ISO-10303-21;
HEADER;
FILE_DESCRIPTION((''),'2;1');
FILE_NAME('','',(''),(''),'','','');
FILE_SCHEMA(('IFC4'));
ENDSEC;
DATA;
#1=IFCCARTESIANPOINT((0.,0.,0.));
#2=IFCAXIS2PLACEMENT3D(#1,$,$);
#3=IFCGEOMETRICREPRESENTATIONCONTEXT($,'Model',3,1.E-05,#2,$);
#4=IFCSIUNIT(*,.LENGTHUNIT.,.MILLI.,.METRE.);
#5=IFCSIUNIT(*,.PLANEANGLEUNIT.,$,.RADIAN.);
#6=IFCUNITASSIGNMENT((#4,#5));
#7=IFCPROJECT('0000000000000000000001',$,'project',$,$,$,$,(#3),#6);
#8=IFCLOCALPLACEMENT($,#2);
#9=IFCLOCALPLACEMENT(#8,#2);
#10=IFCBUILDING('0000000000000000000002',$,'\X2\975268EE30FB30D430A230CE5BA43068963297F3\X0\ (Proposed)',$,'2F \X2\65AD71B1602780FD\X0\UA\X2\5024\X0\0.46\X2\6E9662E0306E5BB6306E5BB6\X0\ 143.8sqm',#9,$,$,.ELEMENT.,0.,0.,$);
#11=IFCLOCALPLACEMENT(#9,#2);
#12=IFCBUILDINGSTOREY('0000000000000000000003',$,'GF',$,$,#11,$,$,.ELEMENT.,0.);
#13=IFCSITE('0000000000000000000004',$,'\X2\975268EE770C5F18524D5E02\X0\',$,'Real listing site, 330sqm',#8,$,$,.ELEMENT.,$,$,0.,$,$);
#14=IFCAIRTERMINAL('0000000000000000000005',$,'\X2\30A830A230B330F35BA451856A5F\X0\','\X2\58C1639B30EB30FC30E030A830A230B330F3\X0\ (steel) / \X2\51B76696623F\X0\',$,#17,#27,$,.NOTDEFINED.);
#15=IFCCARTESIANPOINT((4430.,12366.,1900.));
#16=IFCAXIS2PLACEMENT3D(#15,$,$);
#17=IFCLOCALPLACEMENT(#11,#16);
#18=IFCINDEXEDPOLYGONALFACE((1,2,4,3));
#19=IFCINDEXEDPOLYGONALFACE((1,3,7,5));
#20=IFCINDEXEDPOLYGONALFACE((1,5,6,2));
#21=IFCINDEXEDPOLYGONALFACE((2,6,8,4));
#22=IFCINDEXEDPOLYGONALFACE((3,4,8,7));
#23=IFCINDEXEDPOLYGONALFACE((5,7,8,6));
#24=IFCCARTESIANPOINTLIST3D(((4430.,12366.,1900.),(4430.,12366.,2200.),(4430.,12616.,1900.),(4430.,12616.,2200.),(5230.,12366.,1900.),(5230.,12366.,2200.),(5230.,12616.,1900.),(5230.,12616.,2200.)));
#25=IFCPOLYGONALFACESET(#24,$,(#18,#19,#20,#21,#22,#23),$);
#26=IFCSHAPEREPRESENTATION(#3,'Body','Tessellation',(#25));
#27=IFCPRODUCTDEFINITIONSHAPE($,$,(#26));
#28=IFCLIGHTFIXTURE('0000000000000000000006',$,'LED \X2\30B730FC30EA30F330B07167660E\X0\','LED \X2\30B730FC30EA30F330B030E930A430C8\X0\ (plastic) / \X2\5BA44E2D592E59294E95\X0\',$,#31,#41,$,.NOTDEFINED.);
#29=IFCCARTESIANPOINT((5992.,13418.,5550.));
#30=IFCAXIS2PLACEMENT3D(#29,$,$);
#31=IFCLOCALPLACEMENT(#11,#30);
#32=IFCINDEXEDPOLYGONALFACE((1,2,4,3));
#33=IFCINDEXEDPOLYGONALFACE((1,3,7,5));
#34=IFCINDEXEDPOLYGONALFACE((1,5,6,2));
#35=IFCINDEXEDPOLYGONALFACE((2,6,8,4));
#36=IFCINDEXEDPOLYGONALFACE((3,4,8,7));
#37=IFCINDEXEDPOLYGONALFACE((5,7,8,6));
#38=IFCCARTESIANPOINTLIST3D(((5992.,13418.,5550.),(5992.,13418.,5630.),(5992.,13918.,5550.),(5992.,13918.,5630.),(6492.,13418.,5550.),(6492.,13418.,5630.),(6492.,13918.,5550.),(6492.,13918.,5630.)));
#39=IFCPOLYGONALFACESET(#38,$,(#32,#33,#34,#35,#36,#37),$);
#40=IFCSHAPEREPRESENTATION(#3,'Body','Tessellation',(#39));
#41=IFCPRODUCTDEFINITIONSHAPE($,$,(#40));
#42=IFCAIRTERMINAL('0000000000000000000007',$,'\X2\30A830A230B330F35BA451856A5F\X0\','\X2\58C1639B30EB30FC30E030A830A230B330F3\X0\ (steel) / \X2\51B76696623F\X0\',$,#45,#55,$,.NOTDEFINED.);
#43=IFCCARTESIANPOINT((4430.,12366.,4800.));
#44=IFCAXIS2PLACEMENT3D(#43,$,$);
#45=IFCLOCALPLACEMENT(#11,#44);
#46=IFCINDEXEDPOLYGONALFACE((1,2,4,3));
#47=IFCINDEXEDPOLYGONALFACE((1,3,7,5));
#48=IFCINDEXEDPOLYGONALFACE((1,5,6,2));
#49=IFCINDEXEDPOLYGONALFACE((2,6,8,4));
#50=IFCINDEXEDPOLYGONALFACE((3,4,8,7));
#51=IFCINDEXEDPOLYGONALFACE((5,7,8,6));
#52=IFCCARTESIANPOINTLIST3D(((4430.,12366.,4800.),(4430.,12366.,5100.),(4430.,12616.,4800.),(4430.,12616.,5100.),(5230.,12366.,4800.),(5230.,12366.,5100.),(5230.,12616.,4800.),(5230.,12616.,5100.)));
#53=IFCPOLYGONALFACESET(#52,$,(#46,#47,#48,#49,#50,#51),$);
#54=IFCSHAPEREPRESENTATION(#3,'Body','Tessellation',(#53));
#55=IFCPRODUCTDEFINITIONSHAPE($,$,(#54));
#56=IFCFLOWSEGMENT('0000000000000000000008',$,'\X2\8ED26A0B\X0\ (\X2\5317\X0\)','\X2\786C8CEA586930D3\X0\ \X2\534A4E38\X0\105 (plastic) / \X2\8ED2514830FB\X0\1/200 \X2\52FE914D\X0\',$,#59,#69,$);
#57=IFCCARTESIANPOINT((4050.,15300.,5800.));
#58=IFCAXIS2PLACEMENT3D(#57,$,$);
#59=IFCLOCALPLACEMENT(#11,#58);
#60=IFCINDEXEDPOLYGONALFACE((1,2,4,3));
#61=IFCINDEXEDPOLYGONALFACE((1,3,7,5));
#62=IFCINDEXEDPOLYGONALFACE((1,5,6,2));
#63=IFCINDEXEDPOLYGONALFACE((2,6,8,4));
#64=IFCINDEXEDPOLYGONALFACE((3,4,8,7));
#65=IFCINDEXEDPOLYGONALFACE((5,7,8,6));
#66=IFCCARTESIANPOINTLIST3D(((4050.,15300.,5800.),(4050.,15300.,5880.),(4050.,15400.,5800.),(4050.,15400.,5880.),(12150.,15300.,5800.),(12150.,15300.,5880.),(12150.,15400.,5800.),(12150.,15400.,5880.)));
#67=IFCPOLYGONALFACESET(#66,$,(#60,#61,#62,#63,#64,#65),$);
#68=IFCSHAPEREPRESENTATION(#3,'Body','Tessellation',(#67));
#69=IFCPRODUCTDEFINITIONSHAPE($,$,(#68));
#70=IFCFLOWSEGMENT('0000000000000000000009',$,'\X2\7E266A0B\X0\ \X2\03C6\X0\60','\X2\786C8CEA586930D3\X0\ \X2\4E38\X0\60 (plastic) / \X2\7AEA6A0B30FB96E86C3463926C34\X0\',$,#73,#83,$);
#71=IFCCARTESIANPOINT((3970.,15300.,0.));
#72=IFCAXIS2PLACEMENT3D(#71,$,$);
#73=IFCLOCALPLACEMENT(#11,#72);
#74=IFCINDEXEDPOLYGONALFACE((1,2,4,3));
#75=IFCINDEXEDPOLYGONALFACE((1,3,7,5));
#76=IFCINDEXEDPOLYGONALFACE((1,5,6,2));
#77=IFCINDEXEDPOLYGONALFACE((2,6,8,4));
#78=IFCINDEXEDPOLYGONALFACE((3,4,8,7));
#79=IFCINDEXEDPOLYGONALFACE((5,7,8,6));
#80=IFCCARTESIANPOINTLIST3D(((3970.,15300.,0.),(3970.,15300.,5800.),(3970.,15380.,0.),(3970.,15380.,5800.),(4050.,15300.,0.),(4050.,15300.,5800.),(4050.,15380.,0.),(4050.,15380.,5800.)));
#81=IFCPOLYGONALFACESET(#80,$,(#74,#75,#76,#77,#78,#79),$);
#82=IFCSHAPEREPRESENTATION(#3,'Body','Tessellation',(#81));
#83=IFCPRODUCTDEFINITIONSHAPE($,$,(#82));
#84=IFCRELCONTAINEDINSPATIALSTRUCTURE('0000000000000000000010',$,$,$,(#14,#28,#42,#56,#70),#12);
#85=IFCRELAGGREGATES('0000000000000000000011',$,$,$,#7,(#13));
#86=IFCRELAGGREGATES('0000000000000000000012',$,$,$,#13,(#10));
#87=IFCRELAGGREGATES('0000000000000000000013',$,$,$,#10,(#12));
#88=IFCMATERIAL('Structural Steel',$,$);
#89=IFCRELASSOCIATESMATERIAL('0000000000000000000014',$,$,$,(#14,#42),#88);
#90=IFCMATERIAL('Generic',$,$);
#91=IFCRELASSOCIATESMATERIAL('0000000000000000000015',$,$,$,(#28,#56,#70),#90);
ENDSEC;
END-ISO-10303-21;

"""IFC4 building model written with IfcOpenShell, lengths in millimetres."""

from ifc_helpers import new_model, si_unit, frame, frame_2d, origin, place, context, project, spatial, rectangle, extrude, material, element, save


model = new_model("IFC4")

# Units and contexts
model_context = context("Model", 3, precision=1e-05, world=origin())
ifc_project = project(units=[si_unit("LENGTHUNIT", "METRE", prefix="MILLI"), si_unit("PLANEANGLEUNIT", "RADIAN")], contexts=[model_context])

# Site, building, storey
site_placement = place(None, origin())
site = spatial("IfcSite", under=ifc_project, at=site_placement, Name="青森県弘前市", ObjectType="Real listing site, 330sqm", CompositionType="ELEMENT", RefElevation=0.0)
building_placement = place(site_placement, origin())
building = spatial("IfcBuilding", under=site, at=building_placement, Name="青森・ピアノ室と防音 (Proposed)", ObjectType="2F 断熱性能UA値0.46準拠の家の家 143.8sqm", CompositionType="ELEMENT", ElevationOfRefHeight=0.0, ElevationOfTerrain=0.0)
storey_placement = place(building_placement, origin())
storey = spatial("IfcBuildingStorey", under=building, at=storey_placement, Name="GF", CompositionType="ELEMENT", Elevation=0.0)

# Shared definitions
ifc_material_1 = material(Name="Generic")

# Shared definitions
ifc_material_2 = material(Name="Structural Steel")

# Air terminal
air_terminal_1_placement = place(storey_placement, frame((4430.0, 12366.0, 1900.0)))
element("IfcAirTerminal", 1, at=air_terminal_1_placement, inside=storey, material=ifc_material_2, Name="エアコン室内機", Description="壁掛ルームエアコン (steel) / 冷暖房", PredefinedType="NOTDEFINED", context=model_context, shape_type="SweptSolid", body=[
    extrude(rectangle(XDim=800.0, YDim=250.0, at=frame_2d((400.0, 125.0))), frame((4430.0, 12366.0, 1900.0)), (0.0, 0.0, 1.0), 300.0),
])

# Light fixture
light_fixture_placement = place(storey_placement, frame((5992.0, 13418.0, 5550.0)))
element("IfcLightFixture", 2, at=light_fixture_placement, inside=storey, material=ifc_material_1, Name="LED シーリング照明", Description="LED シーリングライト (plastic) / 室中央天井", PredefinedType="NOTDEFINED", context=model_context, shape_type="SweptSolid", body=[
    extrude(rectangle(XDim=500.0, YDim=500.0, at=frame_2d((250.0, 250.0))), frame((5992.0, 13418.0, 5550.0)), (0.0, 0.0, 1.0), 80.0),
])

# Air terminal
air_terminal_2_placement = place(storey_placement, frame((4430.0, 12366.0, 4800.0)))
element("IfcAirTerminal", 3, at=air_terminal_2_placement, inside=storey, material=ifc_material_2, Name="エアコン室内機", Description="壁掛ルームエアコン (steel) / 冷暖房", PredefinedType="NOTDEFINED", context=model_context, shape_type="SweptSolid", body=[
    extrude(rectangle(XDim=800.0, YDim=250.0, at=frame_2d((400.0, 125.0))), frame((4430.0, 12366.0, 4800.0)), (0.0, 0.0, 1.0), 300.0),
])

# Flow segments
flow_segment_1_placement = place(storey_placement, frame((4050.0, 15300.0, 5800.0)))
element("IfcFlowSegment", 4, at=flow_segment_1_placement, inside=storey, material=ifc_material_1, Name="軒樋 (北)", Description="硬質塩ビ 半丸105 (plastic) / 軒先・1/200 勾配", context=model_context, shape_type="SweptSolid", body=[
    extrude(rectangle(XDim=8100.0, YDim=100.0, at=frame_2d((4050.0, 50.0))), frame((4050.0, 15300.0, 5800.0)), (0.0, 0.0, 1.0), 80.0),
])
flow_segment_2_placement = place(storey_placement, frame((3970.0, 15300.0, 0.0)))
element("IfcFlowSegment", 5, at=flow_segment_2_placement, inside=storey, material=ifc_material_1, Name="縦樋 φ60", Description="硬質塩ビ 丸60 (plastic) / 竪樋・雨水排水", context=model_context, shape_type="SweptSolid", body=[
    extrude(rectangle(XDim=80.0, YDim=80.0, at=frame_2d((40.0, 40.0))), frame((3970.0, 15300.0, 0.0)), (0.0, 0.0, 1.0), 5800.0),
])

save(model, "model.ifc")
